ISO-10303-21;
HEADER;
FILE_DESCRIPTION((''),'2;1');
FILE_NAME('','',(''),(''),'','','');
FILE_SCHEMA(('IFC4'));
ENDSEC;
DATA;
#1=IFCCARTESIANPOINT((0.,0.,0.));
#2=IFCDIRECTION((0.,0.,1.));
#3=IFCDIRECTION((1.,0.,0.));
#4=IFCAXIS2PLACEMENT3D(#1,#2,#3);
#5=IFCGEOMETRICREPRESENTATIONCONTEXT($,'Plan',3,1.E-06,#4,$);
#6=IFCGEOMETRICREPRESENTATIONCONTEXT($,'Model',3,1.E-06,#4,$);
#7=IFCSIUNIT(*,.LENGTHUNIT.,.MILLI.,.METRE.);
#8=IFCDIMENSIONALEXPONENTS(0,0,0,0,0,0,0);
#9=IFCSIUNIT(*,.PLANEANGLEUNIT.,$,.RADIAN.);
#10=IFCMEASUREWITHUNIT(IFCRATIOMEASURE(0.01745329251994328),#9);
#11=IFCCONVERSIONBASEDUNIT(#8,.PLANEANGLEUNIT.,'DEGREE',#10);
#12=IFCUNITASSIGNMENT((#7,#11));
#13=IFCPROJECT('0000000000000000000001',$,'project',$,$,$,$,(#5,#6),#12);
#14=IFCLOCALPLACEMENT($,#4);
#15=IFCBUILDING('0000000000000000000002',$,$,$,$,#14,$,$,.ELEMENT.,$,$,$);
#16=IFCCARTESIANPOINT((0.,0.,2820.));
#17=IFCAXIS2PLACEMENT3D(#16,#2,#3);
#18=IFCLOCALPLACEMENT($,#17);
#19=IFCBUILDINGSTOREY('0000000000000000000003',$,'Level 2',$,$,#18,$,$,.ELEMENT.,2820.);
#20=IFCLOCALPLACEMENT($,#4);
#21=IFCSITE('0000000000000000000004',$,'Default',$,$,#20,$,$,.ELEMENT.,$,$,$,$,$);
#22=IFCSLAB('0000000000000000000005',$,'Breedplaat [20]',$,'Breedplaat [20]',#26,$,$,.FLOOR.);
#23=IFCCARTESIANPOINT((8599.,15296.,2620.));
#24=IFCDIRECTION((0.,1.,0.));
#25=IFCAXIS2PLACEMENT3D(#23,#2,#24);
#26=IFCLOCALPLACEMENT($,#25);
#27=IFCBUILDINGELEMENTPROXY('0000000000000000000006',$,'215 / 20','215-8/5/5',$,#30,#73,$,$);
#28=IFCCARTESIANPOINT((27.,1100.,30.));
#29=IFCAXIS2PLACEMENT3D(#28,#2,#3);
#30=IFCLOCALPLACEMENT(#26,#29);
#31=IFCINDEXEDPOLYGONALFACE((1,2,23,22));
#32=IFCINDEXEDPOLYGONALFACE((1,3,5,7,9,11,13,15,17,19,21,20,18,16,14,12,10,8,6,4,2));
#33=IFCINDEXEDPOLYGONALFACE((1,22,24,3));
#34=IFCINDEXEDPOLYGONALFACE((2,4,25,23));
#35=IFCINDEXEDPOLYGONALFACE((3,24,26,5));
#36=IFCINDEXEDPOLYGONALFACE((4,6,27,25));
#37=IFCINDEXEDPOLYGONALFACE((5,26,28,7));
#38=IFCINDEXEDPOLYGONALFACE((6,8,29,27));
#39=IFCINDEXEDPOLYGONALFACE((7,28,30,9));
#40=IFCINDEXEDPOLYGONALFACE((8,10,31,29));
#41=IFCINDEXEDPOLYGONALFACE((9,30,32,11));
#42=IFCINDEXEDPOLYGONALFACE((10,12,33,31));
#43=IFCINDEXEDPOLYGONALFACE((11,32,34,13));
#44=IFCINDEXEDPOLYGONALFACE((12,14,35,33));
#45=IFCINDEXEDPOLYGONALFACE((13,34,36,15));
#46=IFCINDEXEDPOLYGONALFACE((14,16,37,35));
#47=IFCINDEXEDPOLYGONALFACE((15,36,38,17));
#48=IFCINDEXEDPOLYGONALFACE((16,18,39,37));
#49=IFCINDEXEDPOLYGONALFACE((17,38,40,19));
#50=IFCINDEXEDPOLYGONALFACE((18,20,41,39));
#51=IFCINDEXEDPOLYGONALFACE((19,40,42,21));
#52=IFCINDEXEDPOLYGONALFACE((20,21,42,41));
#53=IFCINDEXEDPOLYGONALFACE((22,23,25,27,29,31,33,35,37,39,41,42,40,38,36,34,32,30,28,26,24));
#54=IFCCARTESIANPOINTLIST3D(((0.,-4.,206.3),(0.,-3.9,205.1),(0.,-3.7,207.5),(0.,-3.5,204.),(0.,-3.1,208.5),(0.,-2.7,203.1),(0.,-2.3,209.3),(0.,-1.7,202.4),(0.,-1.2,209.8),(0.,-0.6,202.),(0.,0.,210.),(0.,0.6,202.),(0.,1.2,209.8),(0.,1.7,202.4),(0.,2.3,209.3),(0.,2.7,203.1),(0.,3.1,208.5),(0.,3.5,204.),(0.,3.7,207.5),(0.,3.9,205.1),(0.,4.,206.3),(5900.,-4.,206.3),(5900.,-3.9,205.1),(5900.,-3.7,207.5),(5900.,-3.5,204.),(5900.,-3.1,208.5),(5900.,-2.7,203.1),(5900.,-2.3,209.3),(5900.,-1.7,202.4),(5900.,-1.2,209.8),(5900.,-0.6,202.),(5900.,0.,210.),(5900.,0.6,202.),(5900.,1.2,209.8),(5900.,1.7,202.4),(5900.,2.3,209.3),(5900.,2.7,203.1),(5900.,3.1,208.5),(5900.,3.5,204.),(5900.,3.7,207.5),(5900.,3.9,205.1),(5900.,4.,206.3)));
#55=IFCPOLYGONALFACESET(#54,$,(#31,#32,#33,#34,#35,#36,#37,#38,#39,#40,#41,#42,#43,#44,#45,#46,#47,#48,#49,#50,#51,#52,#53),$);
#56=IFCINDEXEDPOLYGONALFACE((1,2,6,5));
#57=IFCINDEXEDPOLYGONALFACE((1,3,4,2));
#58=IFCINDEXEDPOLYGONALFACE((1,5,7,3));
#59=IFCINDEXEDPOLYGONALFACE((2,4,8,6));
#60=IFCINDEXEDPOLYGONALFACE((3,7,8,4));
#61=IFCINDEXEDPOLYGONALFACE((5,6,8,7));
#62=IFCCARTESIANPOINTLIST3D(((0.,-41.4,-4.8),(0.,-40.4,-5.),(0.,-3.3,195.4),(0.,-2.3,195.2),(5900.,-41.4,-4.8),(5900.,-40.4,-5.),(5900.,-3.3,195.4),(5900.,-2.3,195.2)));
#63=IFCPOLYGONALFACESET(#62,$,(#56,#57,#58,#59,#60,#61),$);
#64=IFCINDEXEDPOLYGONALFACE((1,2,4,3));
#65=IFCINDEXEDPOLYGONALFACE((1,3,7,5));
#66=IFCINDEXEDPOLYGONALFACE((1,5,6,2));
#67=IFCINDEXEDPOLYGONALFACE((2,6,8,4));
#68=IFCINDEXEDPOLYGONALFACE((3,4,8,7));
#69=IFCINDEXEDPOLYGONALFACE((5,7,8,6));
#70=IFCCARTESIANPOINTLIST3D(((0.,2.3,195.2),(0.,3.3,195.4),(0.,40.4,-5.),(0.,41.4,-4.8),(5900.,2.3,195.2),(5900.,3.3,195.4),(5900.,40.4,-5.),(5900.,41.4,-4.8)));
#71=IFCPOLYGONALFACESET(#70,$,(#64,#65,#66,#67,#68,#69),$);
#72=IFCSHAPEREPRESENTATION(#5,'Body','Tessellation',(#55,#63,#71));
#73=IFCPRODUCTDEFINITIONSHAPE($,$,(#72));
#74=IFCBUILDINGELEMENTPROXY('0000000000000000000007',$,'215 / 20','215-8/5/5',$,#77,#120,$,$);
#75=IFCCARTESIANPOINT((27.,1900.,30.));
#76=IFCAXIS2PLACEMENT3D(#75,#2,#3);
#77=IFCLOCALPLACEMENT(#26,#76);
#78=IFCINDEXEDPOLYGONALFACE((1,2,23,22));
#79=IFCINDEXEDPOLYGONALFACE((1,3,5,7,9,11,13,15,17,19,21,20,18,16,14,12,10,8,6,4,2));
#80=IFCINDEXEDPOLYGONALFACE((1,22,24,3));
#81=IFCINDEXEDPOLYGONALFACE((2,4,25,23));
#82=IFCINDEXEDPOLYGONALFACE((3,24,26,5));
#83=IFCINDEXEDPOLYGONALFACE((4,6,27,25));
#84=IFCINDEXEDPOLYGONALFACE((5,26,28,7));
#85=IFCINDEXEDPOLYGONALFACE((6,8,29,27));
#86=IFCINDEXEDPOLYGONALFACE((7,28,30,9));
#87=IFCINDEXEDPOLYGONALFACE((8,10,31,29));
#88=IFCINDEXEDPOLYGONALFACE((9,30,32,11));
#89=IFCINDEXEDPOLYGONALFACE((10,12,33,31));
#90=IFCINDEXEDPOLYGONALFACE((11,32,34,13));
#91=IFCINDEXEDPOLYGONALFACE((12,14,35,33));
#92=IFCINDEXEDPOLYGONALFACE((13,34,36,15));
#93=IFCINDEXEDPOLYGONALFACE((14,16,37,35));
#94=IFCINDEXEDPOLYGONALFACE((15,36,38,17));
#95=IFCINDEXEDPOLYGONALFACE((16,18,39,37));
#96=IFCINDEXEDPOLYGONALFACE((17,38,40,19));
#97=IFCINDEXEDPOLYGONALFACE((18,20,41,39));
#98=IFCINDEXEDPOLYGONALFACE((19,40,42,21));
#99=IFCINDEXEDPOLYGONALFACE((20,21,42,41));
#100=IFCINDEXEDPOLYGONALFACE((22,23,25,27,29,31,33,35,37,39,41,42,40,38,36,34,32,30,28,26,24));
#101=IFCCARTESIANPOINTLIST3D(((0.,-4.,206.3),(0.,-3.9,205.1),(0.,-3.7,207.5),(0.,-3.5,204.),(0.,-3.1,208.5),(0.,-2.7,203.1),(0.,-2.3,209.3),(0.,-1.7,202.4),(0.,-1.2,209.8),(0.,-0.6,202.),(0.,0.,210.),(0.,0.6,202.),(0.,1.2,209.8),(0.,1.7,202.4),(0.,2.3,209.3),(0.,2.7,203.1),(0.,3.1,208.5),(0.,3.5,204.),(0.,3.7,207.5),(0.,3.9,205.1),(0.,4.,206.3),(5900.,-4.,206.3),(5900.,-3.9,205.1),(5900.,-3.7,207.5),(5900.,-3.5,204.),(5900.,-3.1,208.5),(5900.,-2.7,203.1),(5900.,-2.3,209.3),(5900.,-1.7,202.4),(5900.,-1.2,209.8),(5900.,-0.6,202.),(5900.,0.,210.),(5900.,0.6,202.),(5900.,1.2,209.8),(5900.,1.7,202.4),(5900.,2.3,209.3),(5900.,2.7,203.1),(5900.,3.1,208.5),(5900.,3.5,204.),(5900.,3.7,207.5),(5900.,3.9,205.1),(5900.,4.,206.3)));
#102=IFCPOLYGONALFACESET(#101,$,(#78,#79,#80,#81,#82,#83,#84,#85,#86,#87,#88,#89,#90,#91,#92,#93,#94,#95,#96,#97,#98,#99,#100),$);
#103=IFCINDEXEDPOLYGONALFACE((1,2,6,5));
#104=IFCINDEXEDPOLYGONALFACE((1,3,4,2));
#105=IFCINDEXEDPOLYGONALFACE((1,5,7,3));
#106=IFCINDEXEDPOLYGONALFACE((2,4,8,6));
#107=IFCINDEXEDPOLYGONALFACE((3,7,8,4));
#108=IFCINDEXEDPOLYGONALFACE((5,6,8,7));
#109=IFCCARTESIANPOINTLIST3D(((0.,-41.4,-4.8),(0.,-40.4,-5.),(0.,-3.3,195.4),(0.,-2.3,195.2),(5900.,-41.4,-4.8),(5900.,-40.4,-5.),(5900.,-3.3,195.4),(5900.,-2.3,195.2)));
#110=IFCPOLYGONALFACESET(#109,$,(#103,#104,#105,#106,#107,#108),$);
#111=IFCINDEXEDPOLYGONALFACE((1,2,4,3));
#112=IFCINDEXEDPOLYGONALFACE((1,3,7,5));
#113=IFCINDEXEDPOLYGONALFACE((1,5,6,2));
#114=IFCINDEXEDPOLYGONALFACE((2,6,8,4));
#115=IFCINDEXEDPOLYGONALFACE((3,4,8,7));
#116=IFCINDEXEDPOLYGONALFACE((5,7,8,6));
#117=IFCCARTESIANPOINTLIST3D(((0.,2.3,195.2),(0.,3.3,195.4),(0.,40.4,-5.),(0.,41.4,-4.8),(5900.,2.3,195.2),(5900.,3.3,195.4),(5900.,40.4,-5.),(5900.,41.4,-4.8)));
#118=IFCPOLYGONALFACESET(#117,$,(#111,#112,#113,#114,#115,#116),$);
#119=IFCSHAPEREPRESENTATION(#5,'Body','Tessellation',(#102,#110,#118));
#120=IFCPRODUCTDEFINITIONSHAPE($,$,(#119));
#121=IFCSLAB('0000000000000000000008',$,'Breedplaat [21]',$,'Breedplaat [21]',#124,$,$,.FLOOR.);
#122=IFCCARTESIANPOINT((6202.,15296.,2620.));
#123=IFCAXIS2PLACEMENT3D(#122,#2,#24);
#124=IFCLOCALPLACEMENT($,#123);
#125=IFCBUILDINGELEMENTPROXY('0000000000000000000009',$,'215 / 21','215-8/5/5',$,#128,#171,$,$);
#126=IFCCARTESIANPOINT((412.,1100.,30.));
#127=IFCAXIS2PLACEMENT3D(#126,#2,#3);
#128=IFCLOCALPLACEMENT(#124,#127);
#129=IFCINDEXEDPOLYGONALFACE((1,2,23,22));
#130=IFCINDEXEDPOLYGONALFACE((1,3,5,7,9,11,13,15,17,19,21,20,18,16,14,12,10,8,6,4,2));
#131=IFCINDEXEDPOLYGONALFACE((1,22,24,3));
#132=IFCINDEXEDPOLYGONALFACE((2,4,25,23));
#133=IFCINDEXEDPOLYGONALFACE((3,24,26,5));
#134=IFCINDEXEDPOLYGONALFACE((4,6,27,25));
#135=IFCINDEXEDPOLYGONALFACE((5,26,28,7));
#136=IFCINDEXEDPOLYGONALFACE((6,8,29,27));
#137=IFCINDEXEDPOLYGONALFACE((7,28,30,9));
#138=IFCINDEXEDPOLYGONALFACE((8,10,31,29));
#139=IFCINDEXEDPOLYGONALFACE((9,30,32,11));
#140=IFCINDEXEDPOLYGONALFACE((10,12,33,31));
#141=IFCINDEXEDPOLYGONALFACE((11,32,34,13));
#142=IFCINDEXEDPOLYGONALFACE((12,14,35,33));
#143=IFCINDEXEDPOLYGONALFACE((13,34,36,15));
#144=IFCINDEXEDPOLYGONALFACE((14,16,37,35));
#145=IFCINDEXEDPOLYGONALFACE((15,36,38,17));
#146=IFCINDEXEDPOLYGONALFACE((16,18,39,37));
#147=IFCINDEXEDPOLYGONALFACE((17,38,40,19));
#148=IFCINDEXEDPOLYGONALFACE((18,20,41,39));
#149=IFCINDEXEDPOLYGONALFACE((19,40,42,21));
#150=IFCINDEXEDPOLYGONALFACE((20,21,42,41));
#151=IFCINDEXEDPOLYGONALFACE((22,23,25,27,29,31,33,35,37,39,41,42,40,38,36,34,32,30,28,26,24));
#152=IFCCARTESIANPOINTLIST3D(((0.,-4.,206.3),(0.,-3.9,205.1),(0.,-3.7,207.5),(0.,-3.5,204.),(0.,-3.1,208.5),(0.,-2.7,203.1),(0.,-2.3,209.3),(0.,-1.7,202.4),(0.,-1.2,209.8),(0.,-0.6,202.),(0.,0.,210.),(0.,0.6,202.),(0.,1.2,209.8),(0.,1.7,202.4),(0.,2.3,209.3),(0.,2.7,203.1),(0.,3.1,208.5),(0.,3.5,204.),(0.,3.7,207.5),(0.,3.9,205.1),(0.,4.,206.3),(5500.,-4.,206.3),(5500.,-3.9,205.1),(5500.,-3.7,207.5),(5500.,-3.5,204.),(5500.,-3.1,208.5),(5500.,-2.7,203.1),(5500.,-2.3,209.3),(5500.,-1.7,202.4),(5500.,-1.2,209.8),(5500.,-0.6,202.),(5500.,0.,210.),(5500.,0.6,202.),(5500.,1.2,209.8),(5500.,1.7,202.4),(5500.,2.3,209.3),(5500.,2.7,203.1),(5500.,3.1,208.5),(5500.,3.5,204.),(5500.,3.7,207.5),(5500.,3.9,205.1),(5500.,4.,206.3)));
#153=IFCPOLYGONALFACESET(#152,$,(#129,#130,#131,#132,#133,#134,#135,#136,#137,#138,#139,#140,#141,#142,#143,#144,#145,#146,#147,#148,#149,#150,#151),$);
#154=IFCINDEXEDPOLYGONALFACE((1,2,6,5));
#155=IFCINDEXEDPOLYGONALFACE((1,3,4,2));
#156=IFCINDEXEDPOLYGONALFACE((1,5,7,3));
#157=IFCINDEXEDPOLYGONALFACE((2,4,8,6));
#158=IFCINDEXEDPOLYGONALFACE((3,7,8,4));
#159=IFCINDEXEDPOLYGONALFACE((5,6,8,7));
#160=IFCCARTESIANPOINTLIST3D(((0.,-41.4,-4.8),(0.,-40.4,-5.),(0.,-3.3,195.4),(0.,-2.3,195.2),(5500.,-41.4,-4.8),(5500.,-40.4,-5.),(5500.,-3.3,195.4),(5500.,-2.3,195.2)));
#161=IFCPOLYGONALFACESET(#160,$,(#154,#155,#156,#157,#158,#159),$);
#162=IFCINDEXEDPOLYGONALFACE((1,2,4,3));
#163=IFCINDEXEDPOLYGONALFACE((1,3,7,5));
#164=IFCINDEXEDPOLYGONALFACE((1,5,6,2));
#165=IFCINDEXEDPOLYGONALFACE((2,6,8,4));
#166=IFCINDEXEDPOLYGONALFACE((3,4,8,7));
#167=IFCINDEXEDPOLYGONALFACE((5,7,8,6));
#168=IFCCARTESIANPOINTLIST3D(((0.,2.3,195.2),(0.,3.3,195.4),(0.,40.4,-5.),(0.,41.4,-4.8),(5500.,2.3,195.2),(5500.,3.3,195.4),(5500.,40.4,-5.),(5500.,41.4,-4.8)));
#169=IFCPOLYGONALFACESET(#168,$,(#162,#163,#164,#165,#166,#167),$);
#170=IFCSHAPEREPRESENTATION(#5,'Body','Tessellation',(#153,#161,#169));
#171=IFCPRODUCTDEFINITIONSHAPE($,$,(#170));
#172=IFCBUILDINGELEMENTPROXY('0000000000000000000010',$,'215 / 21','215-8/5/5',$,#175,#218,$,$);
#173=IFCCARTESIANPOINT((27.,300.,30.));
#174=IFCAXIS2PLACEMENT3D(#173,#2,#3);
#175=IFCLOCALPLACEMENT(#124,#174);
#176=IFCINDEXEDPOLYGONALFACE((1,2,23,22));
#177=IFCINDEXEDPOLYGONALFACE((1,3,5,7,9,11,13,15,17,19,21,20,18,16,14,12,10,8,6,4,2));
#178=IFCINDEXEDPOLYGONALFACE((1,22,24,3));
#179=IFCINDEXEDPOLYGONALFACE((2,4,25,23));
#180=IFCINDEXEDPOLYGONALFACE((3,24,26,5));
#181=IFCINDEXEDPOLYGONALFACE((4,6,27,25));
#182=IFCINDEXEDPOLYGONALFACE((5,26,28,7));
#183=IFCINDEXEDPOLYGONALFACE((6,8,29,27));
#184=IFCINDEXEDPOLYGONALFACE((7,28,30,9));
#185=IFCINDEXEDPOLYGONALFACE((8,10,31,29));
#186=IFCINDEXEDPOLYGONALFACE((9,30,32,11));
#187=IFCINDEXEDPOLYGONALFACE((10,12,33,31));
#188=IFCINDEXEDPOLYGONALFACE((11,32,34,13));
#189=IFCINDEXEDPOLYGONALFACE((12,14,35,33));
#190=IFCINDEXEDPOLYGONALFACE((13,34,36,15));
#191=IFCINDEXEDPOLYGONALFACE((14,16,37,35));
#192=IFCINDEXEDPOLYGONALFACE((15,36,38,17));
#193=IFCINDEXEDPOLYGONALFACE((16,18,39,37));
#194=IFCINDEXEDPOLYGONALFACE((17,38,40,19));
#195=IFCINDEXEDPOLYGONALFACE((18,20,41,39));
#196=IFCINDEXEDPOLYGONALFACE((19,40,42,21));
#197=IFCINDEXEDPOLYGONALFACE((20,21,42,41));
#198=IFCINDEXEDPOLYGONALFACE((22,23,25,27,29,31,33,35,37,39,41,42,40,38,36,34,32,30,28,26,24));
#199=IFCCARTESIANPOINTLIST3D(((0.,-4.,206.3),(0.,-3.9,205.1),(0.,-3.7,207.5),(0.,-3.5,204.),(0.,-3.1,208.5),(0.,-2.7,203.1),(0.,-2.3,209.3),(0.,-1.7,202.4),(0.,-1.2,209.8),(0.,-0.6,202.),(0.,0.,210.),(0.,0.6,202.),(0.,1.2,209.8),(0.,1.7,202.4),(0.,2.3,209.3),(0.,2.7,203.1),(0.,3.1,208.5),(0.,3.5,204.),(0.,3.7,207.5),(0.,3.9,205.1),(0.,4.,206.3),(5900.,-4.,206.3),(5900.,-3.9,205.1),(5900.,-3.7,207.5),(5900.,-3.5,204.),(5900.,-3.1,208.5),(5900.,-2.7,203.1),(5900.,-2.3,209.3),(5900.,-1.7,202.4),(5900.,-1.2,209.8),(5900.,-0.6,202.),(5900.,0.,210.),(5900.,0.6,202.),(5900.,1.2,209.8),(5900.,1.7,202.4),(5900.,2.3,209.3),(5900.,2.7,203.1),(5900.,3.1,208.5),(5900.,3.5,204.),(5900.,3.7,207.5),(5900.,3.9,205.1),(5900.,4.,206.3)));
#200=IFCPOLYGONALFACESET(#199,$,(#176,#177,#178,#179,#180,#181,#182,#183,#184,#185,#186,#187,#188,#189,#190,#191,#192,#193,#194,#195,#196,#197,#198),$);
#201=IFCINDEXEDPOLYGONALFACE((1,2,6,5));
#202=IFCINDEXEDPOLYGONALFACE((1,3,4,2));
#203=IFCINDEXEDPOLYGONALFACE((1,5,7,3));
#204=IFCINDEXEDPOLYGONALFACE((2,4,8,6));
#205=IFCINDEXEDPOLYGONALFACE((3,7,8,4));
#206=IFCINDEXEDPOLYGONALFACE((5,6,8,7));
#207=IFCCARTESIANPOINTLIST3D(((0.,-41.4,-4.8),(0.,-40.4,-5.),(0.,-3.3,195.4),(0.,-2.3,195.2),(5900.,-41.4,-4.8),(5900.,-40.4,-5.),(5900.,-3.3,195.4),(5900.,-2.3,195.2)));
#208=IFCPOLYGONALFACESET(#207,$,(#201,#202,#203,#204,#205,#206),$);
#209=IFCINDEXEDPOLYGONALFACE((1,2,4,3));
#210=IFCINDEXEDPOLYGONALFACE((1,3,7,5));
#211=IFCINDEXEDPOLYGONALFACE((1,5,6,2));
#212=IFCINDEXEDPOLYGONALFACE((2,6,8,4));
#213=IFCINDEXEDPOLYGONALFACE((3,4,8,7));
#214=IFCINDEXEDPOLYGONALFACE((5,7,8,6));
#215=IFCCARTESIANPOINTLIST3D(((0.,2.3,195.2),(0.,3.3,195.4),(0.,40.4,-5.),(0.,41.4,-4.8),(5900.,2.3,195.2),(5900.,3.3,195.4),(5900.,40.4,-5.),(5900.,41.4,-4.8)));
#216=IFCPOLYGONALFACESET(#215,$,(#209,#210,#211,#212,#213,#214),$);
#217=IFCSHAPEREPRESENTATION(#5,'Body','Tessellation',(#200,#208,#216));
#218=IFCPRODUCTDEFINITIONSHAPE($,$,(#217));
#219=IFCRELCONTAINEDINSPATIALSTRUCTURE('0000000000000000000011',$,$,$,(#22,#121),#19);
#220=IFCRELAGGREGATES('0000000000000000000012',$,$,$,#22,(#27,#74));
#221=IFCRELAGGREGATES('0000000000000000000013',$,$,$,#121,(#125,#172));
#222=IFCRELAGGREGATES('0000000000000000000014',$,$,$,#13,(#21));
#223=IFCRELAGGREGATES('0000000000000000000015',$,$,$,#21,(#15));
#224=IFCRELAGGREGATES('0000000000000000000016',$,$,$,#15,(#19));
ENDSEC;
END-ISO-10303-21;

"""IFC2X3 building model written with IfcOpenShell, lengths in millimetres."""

from ifc_helpers import new_model, entity, si_unit, converted_unit, frame, origin_with_axes, origin_2d_with_axis, place, context, project, spatial, rectangle, circle, extrude, element, aggregate, save


model = new_model("IFC2X3")

# Units and contexts
plan_context = context("Plan", 3, precision=1e-06, world=origin_with_axes())
model_context = context("Model", 3, precision=1e-06, world=origin_with_axes())
ifc_project = project(units=[si_unit("LENGTHUNIT", "METRE", prefix="MILLI"), converted_unit("PLANEANGLEUNIT", "DEGREE", entity("IfcRatioMeasure", 0.01745329251994328), si_unit("PLANEANGLEUNIT", "RADIAN"), dimensions=[0, 0, 0, 0, 0, 0, 0])], contexts=[plan_context, model_context])

# Site, building, storey
site_placement = place(None, origin_with_axes())
site = spatial("IfcSite", under=ifc_project, at=site_placement, Name="Default", CompositionType="ELEMENT")
building_placement = place(None, origin_with_axes())
building = spatial("IfcBuilding", under=site, at=building_placement, CompositionType="ELEMENT")
storey_placement = place(None, frame((0.0, 0.0, 2820.0), z_axis=(0.0, 0.0, 1.0), x_axis=(1.0, 0.0, 0.0)))
storey = spatial("IfcBuildingStorey", under=building, at=storey_placement, Name="Level 2", CompositionType="ELEMENT", Elevation=2820.0)

# Slab, building element proxies
slab_1_placement = place(None, frame((8599.0, 15296.0, 2620.0), z_axis=(0.0, 0.0, 1.0), x_axis=(0.0, 1.0, 0.0)))
slab_1 = element("IfcSlab", 1, at=slab_1_placement, inside=storey, Name="Breedplaat [20]", ObjectType="Breedplaat [20]", PredefinedType="FLOOR")
proxy_1_placement = place(slab_1_placement, frame((27.0, 1100.0, 30.0), z_axis=(0.0, 0.0, 1.0), x_axis=(1.0, 0.0, 0.0)))
proxy_1 = element("IfcBuildingElementProxy", 2, at=proxy_1_placement, Name="215 / 20", Description="215-8/5/5", context=plan_context, shape_type="SweptSolid", body=[
    extrude(circle(Radius=4.0, at=origin_2d_with_axis()), frame((0.0, 0.0, 206.0), z_axis=(1.0, 0.0, 0.0), x_axis=(0.0, 0.0, 1.0)), (0.0, 0.0, 1.0), 5900.0),
    extrude(rectangle(XDim=203.8, YDim=1.0, at=origin_2d_with_axis()), frame((0.0, -21.9, 95.2), z_axis=(1.0, 0.0, 0.0), x_axis=(0.0, 0.187112, 0.982339)), (0.0, 0.0, 1.0), 5900.0),
    extrude(rectangle(XDim=203.8, YDim=1.0, at=origin_2d_with_axis()), frame((0.0, 21.9, 95.2), z_axis=(1.0, 0.0, 0.0), x_axis=(0.0, -0.187112, 0.982339)), (0.0, 0.0, 1.0), 5900.0),
])
proxy_2_placement = place(slab_1_placement, frame((27.0, 1900.0, 30.0), z_axis=(0.0, 0.0, 1.0), x_axis=(1.0, 0.0, 0.0)))
proxy_2 = element("IfcBuildingElementProxy", 3, at=proxy_2_placement, Name="215 / 20", Description="215-8/5/5", context=plan_context, shape_type="SweptSolid", body=[
    extrude(circle(Radius=4.0, at=origin_2d_with_axis()), frame((0.0, 0.0, 206.0), z_axis=(1.0, 0.0, 0.0), x_axis=(0.0, 0.0, 1.0)), (0.0, 0.0, 1.0), 5900.0),
    extrude(rectangle(XDim=203.8, YDim=1.0, at=origin_2d_with_axis()), frame((0.0, -21.9, 95.2), z_axis=(1.0, 0.0, 0.0), x_axis=(0.0, 0.187112, 0.982339)), (0.0, 0.0, 1.0), 5900.0),
    extrude(rectangle(XDim=203.8, YDim=1.0, at=origin_2d_with_axis()), frame((0.0, 21.9, 95.2), z_axis=(1.0, 0.0, 0.0), x_axis=(0.0, -0.187112, 0.982339)), (0.0, 0.0, 1.0), 5900.0),
])
aggregate(slab_1, [proxy_1, proxy_2])

# Slab, building element proxies
slab_2_placement = place(None, frame((6202.0, 15296.0, 2620.0), z_axis=(0.0, 0.0, 1.0), x_axis=(0.0, 1.0, 0.0)))
slab_2 = element("IfcSlab", 4, at=slab_2_placement, inside=storey, Name="Breedplaat [21]", ObjectType="Breedplaat [21]", PredefinedType="FLOOR")
proxy_3_placement = place(slab_2_placement, frame((412.0, 1100.0, 30.0), z_axis=(0.0, 0.0, 1.0), x_axis=(1.0, 0.0, 0.0)))
proxy_3 = element("IfcBuildingElementProxy", 5, at=proxy_3_placement, Name="215 / 21", Description="215-8/5/5", context=plan_context, shape_type="SweptSolid", body=[
    extrude(circle(Radius=4.0, at=origin_2d_with_axis()), frame((0.0, 0.0, 206.0), z_axis=(1.0, 0.0, 0.0), x_axis=(0.0, 0.0, 1.0)), (0.0, 0.0, 1.0), 5500.0),
    extrude(rectangle(XDim=203.8, YDim=1.0, at=origin_2d_with_axis()), frame((0.0, -21.9, 95.2), z_axis=(1.0, 0.0, 0.0), x_axis=(0.0, 0.187112, 0.982339)), (0.0, 0.0, 1.0), 5500.0),
    extrude(rectangle(XDim=203.8, YDim=1.0, at=origin_2d_with_axis()), frame((0.0, 21.9, 95.2), z_axis=(1.0, 0.0, 0.0), x_axis=(0.0, -0.187112, 0.982339)), (0.0, 0.0, 1.0), 5500.0),
])
proxy_4_placement = place(slab_2_placement, frame((27.0, 300.0, 30.0), z_axis=(0.0, 0.0, 1.0), x_axis=(1.0, 0.0, 0.0)))
proxy_4 = element("IfcBuildingElementProxy", 6, at=proxy_4_placement, Name="215 / 21", Description="215-8/5/5", context=plan_context, shape_type="SweptSolid", body=[
    extrude(circle(Radius=4.0, at=origin_2d_with_axis()), frame((0.0, 0.0, 206.0), z_axis=(1.0, 0.0, 0.0), x_axis=(0.0, 0.0, 1.0)), (0.0, 0.0, 1.0), 5900.0),
    extrude(rectangle(XDim=203.8, YDim=1.0, at=origin_2d_with_axis()), frame((0.0, -21.9, 95.2), z_axis=(1.0, 0.0, 0.0), x_axis=(0.0, 0.187112, 0.982339)), (0.0, 0.0, 1.0), 5900.0),
    extrude(rectangle(XDim=203.8, YDim=1.0, at=origin_2d_with_axis()), frame((0.0, 21.9, 95.2), z_axis=(1.0, 0.0, 0.0), x_axis=(0.0, -0.187112, 0.982339)), (0.0, 0.0, 1.0), 5900.0),
])
aggregate(slab_2, [proxy_3, proxy_4])

save(model, "model.ifc")
